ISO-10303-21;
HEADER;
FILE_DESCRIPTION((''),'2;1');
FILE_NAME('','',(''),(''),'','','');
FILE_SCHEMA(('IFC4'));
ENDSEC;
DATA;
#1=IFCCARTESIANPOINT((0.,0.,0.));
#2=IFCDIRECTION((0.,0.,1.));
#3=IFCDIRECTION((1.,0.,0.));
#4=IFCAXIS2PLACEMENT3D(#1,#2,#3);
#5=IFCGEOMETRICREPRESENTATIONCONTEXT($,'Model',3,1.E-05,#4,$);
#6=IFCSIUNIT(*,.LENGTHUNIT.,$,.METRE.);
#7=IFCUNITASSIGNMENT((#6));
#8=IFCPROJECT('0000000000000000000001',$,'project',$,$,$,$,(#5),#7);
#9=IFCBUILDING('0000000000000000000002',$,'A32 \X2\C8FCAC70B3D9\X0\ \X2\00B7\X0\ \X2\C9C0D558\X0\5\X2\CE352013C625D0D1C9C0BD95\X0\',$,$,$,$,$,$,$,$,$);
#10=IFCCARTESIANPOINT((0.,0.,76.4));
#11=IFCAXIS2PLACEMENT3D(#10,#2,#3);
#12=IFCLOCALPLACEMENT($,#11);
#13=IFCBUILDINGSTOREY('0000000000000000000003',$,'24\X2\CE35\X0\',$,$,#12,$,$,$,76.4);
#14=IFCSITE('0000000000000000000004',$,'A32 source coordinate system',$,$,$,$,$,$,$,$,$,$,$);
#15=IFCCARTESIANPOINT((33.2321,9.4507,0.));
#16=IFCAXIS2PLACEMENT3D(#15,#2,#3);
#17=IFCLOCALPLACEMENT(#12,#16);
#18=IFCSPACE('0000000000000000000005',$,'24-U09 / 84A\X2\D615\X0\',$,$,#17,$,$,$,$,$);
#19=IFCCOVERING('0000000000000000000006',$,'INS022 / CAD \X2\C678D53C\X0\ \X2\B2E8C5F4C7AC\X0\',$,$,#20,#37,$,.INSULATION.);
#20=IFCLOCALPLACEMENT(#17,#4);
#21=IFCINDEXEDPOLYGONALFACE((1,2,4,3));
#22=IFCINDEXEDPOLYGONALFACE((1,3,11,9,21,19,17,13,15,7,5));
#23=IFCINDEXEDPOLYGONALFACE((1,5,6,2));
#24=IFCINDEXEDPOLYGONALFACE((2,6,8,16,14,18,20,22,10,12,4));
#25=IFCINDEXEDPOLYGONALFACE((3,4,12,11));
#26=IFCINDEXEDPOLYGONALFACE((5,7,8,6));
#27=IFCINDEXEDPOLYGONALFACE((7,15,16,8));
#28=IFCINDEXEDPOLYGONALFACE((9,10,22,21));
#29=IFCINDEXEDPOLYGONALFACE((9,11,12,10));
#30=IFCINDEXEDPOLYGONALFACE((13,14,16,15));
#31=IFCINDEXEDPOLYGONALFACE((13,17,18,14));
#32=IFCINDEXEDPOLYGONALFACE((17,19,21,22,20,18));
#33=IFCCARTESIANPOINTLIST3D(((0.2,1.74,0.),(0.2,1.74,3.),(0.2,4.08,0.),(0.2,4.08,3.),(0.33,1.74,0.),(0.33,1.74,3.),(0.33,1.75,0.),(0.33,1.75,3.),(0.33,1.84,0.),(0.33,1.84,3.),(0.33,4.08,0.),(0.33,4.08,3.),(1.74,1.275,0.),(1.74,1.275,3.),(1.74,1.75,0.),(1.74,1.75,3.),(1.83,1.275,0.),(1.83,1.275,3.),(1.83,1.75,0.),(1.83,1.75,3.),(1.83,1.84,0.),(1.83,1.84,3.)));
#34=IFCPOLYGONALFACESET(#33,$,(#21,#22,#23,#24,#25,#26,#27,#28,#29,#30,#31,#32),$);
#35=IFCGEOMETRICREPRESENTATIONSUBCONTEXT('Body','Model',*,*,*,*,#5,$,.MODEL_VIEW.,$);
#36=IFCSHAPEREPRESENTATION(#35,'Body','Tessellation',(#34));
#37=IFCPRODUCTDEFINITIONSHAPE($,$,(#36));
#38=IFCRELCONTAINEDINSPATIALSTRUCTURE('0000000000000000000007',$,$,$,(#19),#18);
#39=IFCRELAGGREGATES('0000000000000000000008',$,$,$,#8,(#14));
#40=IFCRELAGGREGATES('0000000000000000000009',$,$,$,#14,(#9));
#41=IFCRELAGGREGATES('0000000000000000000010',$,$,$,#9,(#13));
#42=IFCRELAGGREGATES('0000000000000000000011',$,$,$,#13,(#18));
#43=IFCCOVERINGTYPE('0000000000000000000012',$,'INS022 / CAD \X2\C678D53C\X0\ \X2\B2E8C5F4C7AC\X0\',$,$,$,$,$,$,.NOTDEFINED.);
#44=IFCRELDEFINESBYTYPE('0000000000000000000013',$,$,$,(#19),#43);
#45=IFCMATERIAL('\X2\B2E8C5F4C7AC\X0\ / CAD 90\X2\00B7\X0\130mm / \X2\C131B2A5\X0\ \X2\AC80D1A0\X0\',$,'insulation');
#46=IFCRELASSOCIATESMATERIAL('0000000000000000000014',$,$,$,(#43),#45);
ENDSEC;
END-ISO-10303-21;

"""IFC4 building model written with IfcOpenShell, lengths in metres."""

from ifc_helpers import new_model, si_unit, frame, origin, origin_with_axes, place, context, subcontext, project, spatial, polyline, outline, extrude, source, transform, mapped, material, type_object, type_shapes, element, save


model = new_model("IFC4")

# Units and contexts
model_context = context("Model", 3, precision=1e-05, world=origin_with_axes())
body_context = subcontext(model_context, "Body", "Model", "MODEL_VIEW")
ifc_project = project(units=[si_unit("LENGTHUNIT", "METRE")], contexts=[model_context])

# Site, building, storey, space
site = spatial("IfcSite", under=ifc_project, Name="A32 source coordinate system")
building = spatial("IfcBuilding", under=site, Name="A32 주거동 · 지하5층–옥탑지붕")
storey_placement = place(None, frame((0.0, 0.0, 76.4), z_axis=(0.0, 0.0, 1.0), x_axis=(1.0, 0.0, 0.0)))
storey = spatial("IfcBuildingStorey", under=building, at=storey_placement, Name="24층", Elevation=76.4)
space_placement = place(storey_placement, frame((33.2321, 9.4507, 0.0), z_axis=(0.0, 0.0, 1.0), x_axis=(1.0, 0.0, 0.0)))
space = spatial("IfcSpace", under=storey, at=space_placement, Name="24-U09 / 84A형")

# Covering
ifc_material = material(Name="단열재 / CAD 90·130mm / 성능 검토", Category="insulation")
covering_type_1 = type_object("IfcCoveringType", Name="INS022 / CAD 외피 단열재", PredefinedType="NOTDEFINED", material=ifc_material)
shared_shape_1 = source(origin(), body_context, "Body", "SweptSolid", [
    extrude(outline(polyline([(1.83, 1.84), (1.83, 1.75), (1.83, 1.275), (1.74, 1.275), (1.74, 1.75), (0.33, 1.75), (0.33, 1.74), (0.2, 1.74), (0.2, 4.08), (0.33, 4.08), (0.33, 1.84), (1.83, 1.84)])), origin(), (0.0, 0.0, 1.0), 3.0),
])
type_shapes(covering_type_1, [shared_shape_1])
covering_1_placement = place(space_placement, origin_with_axes())
element("IfcCovering", 1, at=covering_1_placement, inside=space, type_object=covering_type_1, Name="INS022 / CAD 외피 단열재", PredefinedType="INSULATION", context=body_context, shape_type="MappedRepresentation", body=[
    mapped(shared_shape_1, transform((0.0, 0.0, 0.0), scale=1.0)),
])

save(model, "model.ifc")
